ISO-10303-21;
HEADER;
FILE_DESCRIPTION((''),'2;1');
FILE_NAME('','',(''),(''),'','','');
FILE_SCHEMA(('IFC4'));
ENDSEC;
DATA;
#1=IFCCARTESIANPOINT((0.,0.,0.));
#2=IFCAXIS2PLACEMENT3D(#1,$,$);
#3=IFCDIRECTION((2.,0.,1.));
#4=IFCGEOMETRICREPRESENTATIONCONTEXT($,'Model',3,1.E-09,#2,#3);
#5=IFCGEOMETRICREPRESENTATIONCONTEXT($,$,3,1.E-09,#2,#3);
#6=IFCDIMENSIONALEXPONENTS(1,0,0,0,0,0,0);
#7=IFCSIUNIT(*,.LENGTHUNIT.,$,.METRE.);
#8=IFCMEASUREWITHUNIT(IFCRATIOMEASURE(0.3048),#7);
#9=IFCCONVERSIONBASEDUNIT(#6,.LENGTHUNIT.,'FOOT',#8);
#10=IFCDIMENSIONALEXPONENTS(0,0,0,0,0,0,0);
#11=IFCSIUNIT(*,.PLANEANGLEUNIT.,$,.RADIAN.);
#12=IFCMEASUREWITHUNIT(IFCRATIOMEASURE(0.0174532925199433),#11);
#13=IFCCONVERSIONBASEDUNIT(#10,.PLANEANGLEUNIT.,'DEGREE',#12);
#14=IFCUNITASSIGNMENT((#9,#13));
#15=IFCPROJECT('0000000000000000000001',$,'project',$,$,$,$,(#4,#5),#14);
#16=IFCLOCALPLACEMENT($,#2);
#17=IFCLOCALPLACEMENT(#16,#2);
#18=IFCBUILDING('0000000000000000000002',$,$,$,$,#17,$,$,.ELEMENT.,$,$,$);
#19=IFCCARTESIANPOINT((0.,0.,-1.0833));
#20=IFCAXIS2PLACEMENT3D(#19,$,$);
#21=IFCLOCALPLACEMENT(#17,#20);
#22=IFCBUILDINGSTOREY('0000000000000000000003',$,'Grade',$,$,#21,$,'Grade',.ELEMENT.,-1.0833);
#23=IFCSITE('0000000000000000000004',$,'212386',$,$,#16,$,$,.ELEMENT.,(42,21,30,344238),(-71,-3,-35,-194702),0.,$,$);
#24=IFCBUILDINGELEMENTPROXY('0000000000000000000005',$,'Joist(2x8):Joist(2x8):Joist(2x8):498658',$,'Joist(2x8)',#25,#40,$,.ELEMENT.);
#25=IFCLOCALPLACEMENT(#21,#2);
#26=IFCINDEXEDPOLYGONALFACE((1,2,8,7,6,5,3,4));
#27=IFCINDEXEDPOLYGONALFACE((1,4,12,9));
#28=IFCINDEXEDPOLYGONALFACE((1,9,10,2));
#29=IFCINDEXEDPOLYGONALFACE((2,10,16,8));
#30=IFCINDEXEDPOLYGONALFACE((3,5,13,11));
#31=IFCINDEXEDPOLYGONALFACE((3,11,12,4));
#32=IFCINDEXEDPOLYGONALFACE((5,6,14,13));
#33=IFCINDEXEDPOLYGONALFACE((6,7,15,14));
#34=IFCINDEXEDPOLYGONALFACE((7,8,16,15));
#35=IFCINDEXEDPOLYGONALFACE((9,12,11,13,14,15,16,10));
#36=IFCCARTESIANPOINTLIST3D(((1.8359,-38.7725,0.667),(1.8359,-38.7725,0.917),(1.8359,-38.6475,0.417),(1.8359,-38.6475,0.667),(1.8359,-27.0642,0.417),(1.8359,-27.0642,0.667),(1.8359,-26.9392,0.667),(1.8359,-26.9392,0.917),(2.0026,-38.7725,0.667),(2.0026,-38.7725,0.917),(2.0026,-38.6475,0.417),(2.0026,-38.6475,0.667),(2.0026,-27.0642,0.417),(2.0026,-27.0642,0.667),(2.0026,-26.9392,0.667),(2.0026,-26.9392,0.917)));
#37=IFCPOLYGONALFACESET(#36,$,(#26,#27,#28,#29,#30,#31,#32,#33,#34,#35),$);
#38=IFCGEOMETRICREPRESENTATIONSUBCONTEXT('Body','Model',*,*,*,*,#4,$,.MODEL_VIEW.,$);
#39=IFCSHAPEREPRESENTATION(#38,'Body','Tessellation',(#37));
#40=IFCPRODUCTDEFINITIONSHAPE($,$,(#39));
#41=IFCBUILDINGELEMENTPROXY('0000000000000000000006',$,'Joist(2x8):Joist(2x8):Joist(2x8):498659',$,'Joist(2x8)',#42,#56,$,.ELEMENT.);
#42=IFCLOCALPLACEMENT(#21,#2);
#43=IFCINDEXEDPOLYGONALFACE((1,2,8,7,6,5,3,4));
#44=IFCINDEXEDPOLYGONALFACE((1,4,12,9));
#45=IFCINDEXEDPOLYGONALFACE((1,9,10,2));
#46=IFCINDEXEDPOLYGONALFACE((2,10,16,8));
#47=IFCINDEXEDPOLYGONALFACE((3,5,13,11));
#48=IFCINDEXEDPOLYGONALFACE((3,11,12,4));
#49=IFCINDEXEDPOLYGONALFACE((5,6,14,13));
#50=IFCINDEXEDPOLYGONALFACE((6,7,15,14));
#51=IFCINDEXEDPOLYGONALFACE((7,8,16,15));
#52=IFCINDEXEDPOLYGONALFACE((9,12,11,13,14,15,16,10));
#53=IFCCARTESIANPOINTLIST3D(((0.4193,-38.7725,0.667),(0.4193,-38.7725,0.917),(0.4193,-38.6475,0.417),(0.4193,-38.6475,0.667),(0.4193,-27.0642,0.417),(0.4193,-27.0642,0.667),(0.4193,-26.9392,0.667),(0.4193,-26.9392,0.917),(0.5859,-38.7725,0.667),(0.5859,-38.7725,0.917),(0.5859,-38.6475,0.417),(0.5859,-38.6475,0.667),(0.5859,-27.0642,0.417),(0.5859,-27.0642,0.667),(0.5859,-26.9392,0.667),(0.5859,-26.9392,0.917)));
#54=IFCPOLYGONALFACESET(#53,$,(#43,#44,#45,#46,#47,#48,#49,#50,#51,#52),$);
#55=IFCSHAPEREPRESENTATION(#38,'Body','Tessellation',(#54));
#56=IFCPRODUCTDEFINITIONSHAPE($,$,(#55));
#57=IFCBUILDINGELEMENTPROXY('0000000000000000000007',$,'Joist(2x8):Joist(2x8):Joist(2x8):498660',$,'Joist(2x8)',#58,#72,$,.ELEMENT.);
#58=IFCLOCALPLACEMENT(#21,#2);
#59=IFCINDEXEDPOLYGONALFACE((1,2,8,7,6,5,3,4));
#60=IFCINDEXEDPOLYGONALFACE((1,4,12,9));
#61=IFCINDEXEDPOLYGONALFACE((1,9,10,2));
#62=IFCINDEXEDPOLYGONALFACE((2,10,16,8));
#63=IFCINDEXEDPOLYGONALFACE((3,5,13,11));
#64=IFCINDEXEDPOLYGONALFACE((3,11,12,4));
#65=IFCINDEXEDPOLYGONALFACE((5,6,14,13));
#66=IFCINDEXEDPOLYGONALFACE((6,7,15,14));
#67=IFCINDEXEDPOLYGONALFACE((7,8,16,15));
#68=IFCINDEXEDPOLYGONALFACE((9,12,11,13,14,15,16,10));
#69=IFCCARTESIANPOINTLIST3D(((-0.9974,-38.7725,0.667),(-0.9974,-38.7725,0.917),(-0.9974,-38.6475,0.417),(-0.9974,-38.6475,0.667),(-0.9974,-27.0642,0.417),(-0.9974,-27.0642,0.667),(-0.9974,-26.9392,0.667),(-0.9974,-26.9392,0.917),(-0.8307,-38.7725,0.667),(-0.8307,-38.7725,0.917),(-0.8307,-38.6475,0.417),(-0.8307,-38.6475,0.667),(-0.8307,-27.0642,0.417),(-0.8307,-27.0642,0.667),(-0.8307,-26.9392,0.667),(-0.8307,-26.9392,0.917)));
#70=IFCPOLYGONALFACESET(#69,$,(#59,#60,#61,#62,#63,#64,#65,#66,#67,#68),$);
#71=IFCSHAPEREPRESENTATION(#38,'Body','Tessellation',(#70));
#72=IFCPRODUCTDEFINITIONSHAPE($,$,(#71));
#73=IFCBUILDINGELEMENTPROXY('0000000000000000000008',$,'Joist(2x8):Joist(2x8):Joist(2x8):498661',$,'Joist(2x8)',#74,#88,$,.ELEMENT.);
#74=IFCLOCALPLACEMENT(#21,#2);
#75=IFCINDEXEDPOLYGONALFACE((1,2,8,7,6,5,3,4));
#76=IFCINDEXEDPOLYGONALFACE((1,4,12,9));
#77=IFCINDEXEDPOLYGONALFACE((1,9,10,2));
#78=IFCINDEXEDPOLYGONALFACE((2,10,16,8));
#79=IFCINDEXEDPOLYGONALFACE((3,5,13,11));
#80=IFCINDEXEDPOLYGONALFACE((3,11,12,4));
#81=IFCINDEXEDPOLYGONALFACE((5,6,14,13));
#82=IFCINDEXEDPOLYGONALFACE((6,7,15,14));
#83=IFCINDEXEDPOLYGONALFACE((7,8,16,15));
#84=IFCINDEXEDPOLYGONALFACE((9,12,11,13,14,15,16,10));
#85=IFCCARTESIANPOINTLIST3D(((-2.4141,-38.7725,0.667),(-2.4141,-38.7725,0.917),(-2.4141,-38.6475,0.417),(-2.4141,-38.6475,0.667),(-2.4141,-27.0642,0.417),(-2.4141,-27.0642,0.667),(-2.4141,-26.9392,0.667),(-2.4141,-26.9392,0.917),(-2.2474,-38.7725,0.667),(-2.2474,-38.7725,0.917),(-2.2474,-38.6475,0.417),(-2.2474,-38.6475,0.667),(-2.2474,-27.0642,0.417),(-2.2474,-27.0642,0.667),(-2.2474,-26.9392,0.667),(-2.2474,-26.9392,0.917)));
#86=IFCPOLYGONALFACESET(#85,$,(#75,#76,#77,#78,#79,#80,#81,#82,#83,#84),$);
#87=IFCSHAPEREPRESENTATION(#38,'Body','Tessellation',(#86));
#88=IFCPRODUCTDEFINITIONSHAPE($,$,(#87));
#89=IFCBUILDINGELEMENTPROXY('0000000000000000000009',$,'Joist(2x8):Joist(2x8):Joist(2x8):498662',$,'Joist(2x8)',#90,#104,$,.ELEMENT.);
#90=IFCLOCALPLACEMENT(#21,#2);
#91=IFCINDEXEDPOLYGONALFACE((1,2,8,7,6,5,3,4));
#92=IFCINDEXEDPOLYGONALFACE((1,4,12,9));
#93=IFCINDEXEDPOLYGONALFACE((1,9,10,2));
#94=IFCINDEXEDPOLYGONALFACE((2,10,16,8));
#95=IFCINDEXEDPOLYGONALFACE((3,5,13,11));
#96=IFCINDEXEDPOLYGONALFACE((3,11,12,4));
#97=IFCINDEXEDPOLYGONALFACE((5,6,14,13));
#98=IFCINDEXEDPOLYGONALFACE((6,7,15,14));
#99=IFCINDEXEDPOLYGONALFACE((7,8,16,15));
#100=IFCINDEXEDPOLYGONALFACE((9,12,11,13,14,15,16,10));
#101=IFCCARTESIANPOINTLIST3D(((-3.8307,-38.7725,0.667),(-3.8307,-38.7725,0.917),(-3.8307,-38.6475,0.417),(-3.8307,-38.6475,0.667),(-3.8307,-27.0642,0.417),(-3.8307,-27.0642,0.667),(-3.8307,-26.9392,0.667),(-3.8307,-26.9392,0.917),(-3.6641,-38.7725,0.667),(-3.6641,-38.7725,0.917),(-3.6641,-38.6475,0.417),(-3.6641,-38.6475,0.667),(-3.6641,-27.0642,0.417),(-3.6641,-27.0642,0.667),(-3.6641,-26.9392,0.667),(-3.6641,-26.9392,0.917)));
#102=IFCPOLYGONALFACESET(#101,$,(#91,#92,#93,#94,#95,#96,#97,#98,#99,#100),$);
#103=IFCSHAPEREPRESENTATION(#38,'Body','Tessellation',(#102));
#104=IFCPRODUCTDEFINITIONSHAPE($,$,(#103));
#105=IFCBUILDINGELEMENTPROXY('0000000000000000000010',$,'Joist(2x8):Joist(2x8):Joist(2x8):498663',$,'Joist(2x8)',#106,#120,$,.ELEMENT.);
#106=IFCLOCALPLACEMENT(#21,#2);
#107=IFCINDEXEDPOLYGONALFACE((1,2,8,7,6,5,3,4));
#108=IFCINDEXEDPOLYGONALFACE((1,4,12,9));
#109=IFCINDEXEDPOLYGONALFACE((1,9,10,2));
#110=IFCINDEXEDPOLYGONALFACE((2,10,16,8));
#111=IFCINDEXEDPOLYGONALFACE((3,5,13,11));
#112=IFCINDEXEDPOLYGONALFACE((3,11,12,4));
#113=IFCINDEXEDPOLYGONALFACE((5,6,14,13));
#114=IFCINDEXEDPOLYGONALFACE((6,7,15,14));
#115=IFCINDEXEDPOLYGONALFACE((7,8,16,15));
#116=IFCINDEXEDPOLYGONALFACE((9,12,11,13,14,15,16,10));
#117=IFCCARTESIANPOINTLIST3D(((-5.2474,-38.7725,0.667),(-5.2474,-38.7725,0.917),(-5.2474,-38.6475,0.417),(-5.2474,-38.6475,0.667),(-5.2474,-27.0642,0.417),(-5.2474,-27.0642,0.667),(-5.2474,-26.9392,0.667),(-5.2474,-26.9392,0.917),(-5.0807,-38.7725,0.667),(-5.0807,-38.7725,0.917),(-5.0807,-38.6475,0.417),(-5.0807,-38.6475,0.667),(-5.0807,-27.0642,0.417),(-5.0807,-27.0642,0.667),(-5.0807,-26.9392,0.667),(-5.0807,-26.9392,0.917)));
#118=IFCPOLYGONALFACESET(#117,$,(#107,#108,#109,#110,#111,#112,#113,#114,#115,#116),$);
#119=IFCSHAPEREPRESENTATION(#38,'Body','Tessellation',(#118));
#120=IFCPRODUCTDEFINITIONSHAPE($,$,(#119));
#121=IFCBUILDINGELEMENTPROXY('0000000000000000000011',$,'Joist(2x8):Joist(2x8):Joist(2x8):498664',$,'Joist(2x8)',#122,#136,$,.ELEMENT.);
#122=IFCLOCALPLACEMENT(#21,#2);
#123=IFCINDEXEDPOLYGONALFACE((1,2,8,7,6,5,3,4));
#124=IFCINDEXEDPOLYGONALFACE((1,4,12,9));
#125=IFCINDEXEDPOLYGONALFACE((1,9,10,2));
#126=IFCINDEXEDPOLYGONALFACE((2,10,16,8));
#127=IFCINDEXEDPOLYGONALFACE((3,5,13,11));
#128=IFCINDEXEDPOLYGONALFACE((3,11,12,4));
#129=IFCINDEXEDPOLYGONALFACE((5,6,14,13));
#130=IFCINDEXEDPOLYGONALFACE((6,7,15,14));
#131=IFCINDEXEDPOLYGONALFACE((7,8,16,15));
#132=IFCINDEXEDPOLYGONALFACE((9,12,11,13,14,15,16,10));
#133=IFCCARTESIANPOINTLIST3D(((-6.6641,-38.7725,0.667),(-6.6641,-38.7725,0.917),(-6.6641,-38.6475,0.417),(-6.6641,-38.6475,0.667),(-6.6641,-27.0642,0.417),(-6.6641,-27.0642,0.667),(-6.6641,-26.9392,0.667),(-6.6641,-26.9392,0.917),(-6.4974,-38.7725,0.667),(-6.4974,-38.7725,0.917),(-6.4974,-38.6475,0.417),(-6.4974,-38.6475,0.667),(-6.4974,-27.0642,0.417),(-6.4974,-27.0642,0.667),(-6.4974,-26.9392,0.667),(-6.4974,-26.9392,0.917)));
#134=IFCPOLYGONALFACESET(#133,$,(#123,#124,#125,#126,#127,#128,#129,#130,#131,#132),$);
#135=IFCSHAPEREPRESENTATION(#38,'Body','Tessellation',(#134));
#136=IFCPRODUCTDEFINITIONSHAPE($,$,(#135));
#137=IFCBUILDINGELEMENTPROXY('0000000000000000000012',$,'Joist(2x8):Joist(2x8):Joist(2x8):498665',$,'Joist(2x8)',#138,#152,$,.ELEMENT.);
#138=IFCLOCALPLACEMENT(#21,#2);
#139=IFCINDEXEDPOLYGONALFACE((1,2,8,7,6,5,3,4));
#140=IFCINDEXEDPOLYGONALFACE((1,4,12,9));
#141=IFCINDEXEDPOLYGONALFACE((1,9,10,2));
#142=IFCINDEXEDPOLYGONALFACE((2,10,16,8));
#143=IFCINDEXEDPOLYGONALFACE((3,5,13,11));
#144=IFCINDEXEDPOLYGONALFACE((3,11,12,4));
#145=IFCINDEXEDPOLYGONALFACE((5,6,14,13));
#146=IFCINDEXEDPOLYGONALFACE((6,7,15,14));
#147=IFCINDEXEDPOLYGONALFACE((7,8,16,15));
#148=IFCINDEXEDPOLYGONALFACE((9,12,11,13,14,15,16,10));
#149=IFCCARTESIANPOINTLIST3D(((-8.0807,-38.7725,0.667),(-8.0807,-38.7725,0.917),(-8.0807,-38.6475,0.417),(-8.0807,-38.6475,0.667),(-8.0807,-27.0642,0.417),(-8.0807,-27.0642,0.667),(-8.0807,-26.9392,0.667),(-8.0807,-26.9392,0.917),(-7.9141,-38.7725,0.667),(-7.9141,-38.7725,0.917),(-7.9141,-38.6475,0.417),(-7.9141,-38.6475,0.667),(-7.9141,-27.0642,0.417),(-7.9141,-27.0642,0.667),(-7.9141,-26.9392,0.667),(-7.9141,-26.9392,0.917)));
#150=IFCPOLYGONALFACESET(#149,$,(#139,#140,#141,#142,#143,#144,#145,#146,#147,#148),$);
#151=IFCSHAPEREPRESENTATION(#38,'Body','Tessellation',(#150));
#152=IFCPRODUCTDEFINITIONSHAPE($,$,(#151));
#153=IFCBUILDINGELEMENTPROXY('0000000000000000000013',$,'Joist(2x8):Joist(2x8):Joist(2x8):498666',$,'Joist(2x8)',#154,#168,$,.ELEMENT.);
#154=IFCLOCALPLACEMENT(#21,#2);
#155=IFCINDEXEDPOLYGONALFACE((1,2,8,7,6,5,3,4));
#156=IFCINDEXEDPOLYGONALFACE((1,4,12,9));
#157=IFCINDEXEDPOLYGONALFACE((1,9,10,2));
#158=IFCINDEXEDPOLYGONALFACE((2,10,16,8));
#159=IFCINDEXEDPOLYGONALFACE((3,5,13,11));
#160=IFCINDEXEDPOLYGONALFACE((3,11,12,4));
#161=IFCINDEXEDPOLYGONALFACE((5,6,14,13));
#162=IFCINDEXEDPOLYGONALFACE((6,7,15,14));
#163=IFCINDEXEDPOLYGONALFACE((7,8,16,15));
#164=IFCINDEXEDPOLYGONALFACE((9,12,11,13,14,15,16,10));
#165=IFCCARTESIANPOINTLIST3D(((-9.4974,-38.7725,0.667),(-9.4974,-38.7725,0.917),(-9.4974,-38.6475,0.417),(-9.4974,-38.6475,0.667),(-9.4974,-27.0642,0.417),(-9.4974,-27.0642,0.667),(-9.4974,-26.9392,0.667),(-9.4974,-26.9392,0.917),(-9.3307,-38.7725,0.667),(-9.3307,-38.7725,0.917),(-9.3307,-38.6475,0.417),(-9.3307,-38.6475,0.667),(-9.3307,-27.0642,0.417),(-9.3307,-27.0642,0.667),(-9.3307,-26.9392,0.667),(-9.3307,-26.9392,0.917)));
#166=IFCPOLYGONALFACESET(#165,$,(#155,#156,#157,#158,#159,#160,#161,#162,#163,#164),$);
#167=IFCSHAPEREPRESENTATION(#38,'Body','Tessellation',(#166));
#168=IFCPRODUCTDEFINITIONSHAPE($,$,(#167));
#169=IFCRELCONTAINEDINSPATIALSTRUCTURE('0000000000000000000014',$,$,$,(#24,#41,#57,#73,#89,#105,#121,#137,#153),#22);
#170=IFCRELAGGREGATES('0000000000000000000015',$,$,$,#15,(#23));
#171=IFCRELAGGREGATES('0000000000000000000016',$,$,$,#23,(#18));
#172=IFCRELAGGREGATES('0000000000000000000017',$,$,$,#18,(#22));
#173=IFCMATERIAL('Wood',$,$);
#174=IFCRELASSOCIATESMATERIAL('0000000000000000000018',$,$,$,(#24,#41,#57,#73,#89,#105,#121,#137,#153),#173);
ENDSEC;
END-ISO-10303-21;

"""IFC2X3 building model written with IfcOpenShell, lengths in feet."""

from ifc_helpers import new_model, entity, si_unit, converted_unit, direction, frame, origin, place, context, subcontext, project, spatial, polyline, outline, extrude, source, transform, mapped, material, element, save


model = new_model("IFC2X3")

# Units and contexts
model_context = context("Model", 3, precision=1e-09, world=origin(), true_north=direction((2.0, 0.0, 1.0)))
context_of_model = context(None, 3, precision=1e-09, world=origin(), true_north=direction((2.0, 0.0, 1.0)))
body_context = subcontext(model_context, "Body", "Model", "MODEL_VIEW")
ifc_project = project(units=[converted_unit("LENGTHUNIT", "FOOT", entity("IfcRatioMeasure", 0.3048), si_unit("LENGTHUNIT", "METRE"), dimensions=[1, 0, 0, 0, 0, 0, 0]), converted_unit("PLANEANGLEUNIT", "DEGREE", entity("IfcRatioMeasure", 0.0174532925199433), si_unit("PLANEANGLEUNIT", "RADIAN"), dimensions=[0, 0, 0, 0, 0, 0, 0])], contexts=[model_context, context_of_model])

# Site, building, storey
site_placement = place(None, origin())
site = spatial("IfcSite", under=ifc_project, at=site_placement, Name="212386", CompositionType="ELEMENT", RefLatitude=(42, 21, 30, 344238), RefLongitude=(-71, -3, -35, -194702), RefElevation=0.0)
building_placement = place(site_placement, origin())
building = spatial("IfcBuilding", under=site, at=building_placement, CompositionType="ELEMENT")
storey_placement = place(building_placement, frame((0.0, 0.0, -1.0833)))
storey = spatial("IfcBuildingStorey", under=building, at=storey_placement, Name="Grade", LongName="Grade", CompositionType="ELEMENT", Elevation=-1.0833)

# Building element proxies
ifc_material_1 = material(Name="Wood")
shared_shape_1 = source(origin(), body_context, "Body", "SweptSolid", [
    extrude(outline(polyline([(-0.25, -5.9167), (0.0, -5.9167), (0.0, -5.7917), (0.25, -5.7917), (0.25, 5.7917), (0.0, 5.7917), (0.0, 5.9167), (-0.25, 5.9167), (-0.25, -5.9167)])), frame((1.8359, -32.8558, -0.4164), z_axis=(1.0, 0.0, 0.0), x_axis=(0.0, 0.0, -1.0)), (0.0, 0.0, 1.0), 0.1667),
])
proxy_1_placement = place(storey_placement, frame((0.0, 0.0, 1.0833)))
element("IfcBuildingElementProxy", 1, at=proxy_1_placement, inside=storey, material=ifc_material_1, Name="Joist(2x8):Joist(2x8):Joist(2x8):498658", ObjectType="Joist(2x8)", CompositionType="ELEMENT", context=body_context, shape_type="MappedRepresentation", body=[
    mapped(shared_shape_1, transform((0.0, 0.0, 0.0), scale=1.0)),
])
shared_shape_2 = source(origin(), body_context, "Body", "SweptSolid", [
    extrude(outline(polyline([(-0.25, -5.9167), (0.0, -5.9167), (0.0, -5.7917), (0.25, -5.7917), (0.25, 5.7917), (0.0, 5.7917), (0.0, 5.9167), (-0.25, 5.9167), (-0.25, -5.9167)])), frame((0.4193, -32.8558, -0.4164), z_axis=(1.0, 0.0, 0.0), x_axis=(0.0, 0.0, -1.0)), (0.0, 0.0, 1.0), 0.1667),
])
proxy_2_placement = place(storey_placement, frame((0.0, 0.0, 1.0833)))
element("IfcBuildingElementProxy", 2, at=proxy_2_placement, inside=storey, material=ifc_material_1, Name="Joist(2x8):Joist(2x8):Joist(2x8):498659", ObjectType="Joist(2x8)", CompositionType="ELEMENT", context=body_context, shape_type="MappedRepresentation", body=[
    mapped(shared_shape_2, transform((0.0, 0.0, 0.0), scale=1.0)),
])
shared_shape_3 = source(origin(), body_context, "Body", "SweptSolid", [
    extrude(outline(polyline([(-0.25, -5.9167), (0.0, -5.9167), (0.0, -5.7917), (0.25, -5.7917), (0.25, 5.7917), (0.0, 5.7917), (0.0, 5.9167), (-0.25, 5.9167), (-0.25, -5.9167)])), frame((-0.9974, -32.8558, -0.4164), z_axis=(1.0, 0.0, 0.0), x_axis=(0.0, 0.0, -1.0)), (0.0, 0.0, 1.0), 0.1667),
])
proxy_3_placement = place(storey_placement, frame((0.0, 0.0, 1.0833)))
element("IfcBuildingElementProxy", 3, at=proxy_3_placement, inside=storey, material=ifc_material_1, Name="Joist(2x8):Joist(2x8):Joist(2x8):498660", ObjectType="Joist(2x8)", CompositionType="ELEMENT", context=body_context, shape_type="MappedRepresentation", body=[
    mapped(shared_shape_3, transform((0.0, 0.0, 0.0), scale=1.0)),
])
shared_shape_4 = source(origin(), body_context, "Body", "SweptSolid", [
    extrude(outline(polyline([(-0.25, -5.9167), (0.0, -5.9167), (0.0, -5.7917), (0.25, -5.7917), (0.25, 5.7917), (0.0, 5.7917), (0.0, 5.9167), (-0.25, 5.9167), (-0.25, -5.9167)])), frame((-2.4141, -32.8558, -0.4164), z_axis=(1.0, 0.0, 0.0), x_axis=(0.0, 0.0, -1.0)), (0.0, 0.0, 1.0), 0.1667),
])
proxy_4_placement = place(storey_placement, frame((0.0, 0.0, 1.0833)))
element("IfcBuildingElementProxy", 4, at=proxy_4_placement, inside=storey, material=ifc_material_1, Name="Joist(2x8):Joist(2x8):Joist(2x8):498661", ObjectType="Joist(2x8)", CompositionType="ELEMENT", context=body_context, shape_type="MappedRepresentation", body=[
    mapped(shared_shape_4, transform((0.0, 0.0, 0.0), scale=1.0)),
])
shared_shape_5 = source(origin(), body_context, "Body", "SweptSolid", [
    extrude(outline(polyline([(-0.25, -5.9167), (0.0, -5.9167), (0.0, -5.7917), (0.25, -5.7917), (0.25, 5.7917), (0.0, 5.7917), (0.0, 5.9167), (-0.25, 5.9167), (-0.25, -5.9167)])), frame((-3.8307, -32.8558, -0.4164), z_axis=(1.0, 0.0, 0.0), x_axis=(0.0, 0.0, -1.0)), (0.0, 0.0, 1.0), 0.1667),
])
proxy_5_placement = place(storey_placement, frame((0.0, 0.0, 1.0833)))
element("IfcBuildingElementProxy", 5, at=proxy_5_placement, inside=storey, material=ifc_material_1, Name="Joist(2x8):Joist(2x8):Joist(2x8):498662", ObjectType="Joist(2x8)", CompositionType="ELEMENT", context=body_context, shape_type="MappedRepresentation", body=[
    mapped(shared_shape_5, transform((0.0, 0.0, 0.0), scale=1.0)),
])
shared_shape_6 = source(origin(), body_context, "Body", "SweptSolid", [
    extrude(outline(polyline([(-0.25, -5.9167), (0.0, -5.9167), (0.0, -5.7917), (0.25, -5.7917), (0.25, 5.7917), (0.0, 5.7917), (0.0, 5.9167), (-0.25, 5.9167), (-0.25, -5.9167)])), frame((-5.2474, -32.8558, -0.4164), z_axis=(1.0, 0.0, 0.0), x_axis=(0.0, 0.0, -1.0)), (0.0, 0.0, 1.0), 0.1667),
])
proxy_6_placement = place(storey_placement, frame((0.0, 0.0, 1.0833)))
element("IfcBuildingElementProxy", 6, at=proxy_6_placement, inside=storey, material=ifc_material_1, Name="Joist(2x8):Joist(2x8):Joist(2x8):498663", ObjectType="Joist(2x8)", CompositionType="ELEMENT", context=body_context, shape_type="MappedRepresentation", body=[
    mapped(shared_shape_6, transform((0.0, 0.0, 0.0), scale=1.0)),
])
shared_shape_7 = source(origin(), body_context, "Body", "SweptSolid", [
    extrude(outline(polyline([(-0.25, -5.9167), (0.0, -5.9167), (0.0, -5.7917), (0.25, -5.7917), (0.25, 5.7917), (0.0, 5.7917), (0.0, 5.9167), (-0.25, 5.9167), (-0.25, -5.9167)])), frame((-6.6641, -32.8558, -0.4164), z_axis=(1.0, 0.0, 0.0), x_axis=(0.0, 0.0, -1.0)), (0.0, 0.0, 1.0), 0.1667),
])
proxy_7_placement = place(storey_placement, frame((0.0, 0.0, 1.0833)))
element("IfcBuildingElementProxy", 7, at=proxy_7_placement, inside=storey, material=ifc_material_1, Name="Joist(2x8):Joist(2x8):Joist(2x8):498664", ObjectType="Joist(2x8)", CompositionType="ELEMENT", context=body_context, shape_type="MappedRepresentation", body=[
    mapped(shared_shape_7, transform((0.0, 0.0, 0.0), scale=1.0)),
])
shared_shape_8 = source(origin(), body_context, "Body", "SweptSolid", [
    extrude(outline(polyline([(-0.25, -5.9167), (0.0, -5.9167), (0.0, -5.7917), (0.25, -5.7917), (0.25, 5.7917), (0.0, 5.7917), (0.0, 5.9167), (-0.25, 5.9167), (-0.25, -5.9167)])), frame((-8.0807, -32.8558, -0.4164), z_axis=(1.0, 0.0, 0.0), x_axis=(0.0, 0.0, -1.0)), (0.0, 0.0, 1.0), 0.1667),
])
proxy_8_placement = place(storey_placement, frame((0.0, 0.0, 1.0833)))
element("IfcBuildingElementProxy", 8, at=proxy_8_placement, inside=storey, material=ifc_material_1, Name="Joist(2x8):Joist(2x8):Joist(2x8):498665", ObjectType="Joist(2x8)", CompositionType="ELEMENT", context=body_context, shape_type="MappedRepresentation", body=[
    mapped(shared_shape_8, transform((0.0, 0.0, 0.0), scale=1.0)),
])
shared_shape_9 = source(origin(), body_context, "Body", "SweptSolid", [
    extrude(outline(polyline([(-0.25, -5.9167), (0.0, -5.9167), (0.0, -5.7917), (0.25, -5.7917), (0.25, 5.7917), (0.0, 5.7917), (0.0, 5.9167), (-0.25, 5.9167), (-0.25, -5.9167)])), frame((-9.4974, -32.8558, -0.4164), z_axis=(1.0, 0.0, 0.0), x_axis=(0.0, 0.0, -1.0)), (0.0, 0.0, 1.0), 0.1667),
])
proxy_9_placement = place(storey_placement, frame((0.0, 0.0, 1.0833)))
element("IfcBuildingElementProxy", 9, at=proxy_9_placement, inside=storey, material=ifc_material_1, Name="Joist(2x8):Joist(2x8):Joist(2x8):498666", ObjectType="Joist(2x8)", CompositionType="ELEMENT", context=body_context, shape_type="MappedRepresentation", body=[
    mapped(shared_shape_9, transform((0.0, 0.0, 0.0), scale=1.0)),
])

save(model, "model.ifc")
